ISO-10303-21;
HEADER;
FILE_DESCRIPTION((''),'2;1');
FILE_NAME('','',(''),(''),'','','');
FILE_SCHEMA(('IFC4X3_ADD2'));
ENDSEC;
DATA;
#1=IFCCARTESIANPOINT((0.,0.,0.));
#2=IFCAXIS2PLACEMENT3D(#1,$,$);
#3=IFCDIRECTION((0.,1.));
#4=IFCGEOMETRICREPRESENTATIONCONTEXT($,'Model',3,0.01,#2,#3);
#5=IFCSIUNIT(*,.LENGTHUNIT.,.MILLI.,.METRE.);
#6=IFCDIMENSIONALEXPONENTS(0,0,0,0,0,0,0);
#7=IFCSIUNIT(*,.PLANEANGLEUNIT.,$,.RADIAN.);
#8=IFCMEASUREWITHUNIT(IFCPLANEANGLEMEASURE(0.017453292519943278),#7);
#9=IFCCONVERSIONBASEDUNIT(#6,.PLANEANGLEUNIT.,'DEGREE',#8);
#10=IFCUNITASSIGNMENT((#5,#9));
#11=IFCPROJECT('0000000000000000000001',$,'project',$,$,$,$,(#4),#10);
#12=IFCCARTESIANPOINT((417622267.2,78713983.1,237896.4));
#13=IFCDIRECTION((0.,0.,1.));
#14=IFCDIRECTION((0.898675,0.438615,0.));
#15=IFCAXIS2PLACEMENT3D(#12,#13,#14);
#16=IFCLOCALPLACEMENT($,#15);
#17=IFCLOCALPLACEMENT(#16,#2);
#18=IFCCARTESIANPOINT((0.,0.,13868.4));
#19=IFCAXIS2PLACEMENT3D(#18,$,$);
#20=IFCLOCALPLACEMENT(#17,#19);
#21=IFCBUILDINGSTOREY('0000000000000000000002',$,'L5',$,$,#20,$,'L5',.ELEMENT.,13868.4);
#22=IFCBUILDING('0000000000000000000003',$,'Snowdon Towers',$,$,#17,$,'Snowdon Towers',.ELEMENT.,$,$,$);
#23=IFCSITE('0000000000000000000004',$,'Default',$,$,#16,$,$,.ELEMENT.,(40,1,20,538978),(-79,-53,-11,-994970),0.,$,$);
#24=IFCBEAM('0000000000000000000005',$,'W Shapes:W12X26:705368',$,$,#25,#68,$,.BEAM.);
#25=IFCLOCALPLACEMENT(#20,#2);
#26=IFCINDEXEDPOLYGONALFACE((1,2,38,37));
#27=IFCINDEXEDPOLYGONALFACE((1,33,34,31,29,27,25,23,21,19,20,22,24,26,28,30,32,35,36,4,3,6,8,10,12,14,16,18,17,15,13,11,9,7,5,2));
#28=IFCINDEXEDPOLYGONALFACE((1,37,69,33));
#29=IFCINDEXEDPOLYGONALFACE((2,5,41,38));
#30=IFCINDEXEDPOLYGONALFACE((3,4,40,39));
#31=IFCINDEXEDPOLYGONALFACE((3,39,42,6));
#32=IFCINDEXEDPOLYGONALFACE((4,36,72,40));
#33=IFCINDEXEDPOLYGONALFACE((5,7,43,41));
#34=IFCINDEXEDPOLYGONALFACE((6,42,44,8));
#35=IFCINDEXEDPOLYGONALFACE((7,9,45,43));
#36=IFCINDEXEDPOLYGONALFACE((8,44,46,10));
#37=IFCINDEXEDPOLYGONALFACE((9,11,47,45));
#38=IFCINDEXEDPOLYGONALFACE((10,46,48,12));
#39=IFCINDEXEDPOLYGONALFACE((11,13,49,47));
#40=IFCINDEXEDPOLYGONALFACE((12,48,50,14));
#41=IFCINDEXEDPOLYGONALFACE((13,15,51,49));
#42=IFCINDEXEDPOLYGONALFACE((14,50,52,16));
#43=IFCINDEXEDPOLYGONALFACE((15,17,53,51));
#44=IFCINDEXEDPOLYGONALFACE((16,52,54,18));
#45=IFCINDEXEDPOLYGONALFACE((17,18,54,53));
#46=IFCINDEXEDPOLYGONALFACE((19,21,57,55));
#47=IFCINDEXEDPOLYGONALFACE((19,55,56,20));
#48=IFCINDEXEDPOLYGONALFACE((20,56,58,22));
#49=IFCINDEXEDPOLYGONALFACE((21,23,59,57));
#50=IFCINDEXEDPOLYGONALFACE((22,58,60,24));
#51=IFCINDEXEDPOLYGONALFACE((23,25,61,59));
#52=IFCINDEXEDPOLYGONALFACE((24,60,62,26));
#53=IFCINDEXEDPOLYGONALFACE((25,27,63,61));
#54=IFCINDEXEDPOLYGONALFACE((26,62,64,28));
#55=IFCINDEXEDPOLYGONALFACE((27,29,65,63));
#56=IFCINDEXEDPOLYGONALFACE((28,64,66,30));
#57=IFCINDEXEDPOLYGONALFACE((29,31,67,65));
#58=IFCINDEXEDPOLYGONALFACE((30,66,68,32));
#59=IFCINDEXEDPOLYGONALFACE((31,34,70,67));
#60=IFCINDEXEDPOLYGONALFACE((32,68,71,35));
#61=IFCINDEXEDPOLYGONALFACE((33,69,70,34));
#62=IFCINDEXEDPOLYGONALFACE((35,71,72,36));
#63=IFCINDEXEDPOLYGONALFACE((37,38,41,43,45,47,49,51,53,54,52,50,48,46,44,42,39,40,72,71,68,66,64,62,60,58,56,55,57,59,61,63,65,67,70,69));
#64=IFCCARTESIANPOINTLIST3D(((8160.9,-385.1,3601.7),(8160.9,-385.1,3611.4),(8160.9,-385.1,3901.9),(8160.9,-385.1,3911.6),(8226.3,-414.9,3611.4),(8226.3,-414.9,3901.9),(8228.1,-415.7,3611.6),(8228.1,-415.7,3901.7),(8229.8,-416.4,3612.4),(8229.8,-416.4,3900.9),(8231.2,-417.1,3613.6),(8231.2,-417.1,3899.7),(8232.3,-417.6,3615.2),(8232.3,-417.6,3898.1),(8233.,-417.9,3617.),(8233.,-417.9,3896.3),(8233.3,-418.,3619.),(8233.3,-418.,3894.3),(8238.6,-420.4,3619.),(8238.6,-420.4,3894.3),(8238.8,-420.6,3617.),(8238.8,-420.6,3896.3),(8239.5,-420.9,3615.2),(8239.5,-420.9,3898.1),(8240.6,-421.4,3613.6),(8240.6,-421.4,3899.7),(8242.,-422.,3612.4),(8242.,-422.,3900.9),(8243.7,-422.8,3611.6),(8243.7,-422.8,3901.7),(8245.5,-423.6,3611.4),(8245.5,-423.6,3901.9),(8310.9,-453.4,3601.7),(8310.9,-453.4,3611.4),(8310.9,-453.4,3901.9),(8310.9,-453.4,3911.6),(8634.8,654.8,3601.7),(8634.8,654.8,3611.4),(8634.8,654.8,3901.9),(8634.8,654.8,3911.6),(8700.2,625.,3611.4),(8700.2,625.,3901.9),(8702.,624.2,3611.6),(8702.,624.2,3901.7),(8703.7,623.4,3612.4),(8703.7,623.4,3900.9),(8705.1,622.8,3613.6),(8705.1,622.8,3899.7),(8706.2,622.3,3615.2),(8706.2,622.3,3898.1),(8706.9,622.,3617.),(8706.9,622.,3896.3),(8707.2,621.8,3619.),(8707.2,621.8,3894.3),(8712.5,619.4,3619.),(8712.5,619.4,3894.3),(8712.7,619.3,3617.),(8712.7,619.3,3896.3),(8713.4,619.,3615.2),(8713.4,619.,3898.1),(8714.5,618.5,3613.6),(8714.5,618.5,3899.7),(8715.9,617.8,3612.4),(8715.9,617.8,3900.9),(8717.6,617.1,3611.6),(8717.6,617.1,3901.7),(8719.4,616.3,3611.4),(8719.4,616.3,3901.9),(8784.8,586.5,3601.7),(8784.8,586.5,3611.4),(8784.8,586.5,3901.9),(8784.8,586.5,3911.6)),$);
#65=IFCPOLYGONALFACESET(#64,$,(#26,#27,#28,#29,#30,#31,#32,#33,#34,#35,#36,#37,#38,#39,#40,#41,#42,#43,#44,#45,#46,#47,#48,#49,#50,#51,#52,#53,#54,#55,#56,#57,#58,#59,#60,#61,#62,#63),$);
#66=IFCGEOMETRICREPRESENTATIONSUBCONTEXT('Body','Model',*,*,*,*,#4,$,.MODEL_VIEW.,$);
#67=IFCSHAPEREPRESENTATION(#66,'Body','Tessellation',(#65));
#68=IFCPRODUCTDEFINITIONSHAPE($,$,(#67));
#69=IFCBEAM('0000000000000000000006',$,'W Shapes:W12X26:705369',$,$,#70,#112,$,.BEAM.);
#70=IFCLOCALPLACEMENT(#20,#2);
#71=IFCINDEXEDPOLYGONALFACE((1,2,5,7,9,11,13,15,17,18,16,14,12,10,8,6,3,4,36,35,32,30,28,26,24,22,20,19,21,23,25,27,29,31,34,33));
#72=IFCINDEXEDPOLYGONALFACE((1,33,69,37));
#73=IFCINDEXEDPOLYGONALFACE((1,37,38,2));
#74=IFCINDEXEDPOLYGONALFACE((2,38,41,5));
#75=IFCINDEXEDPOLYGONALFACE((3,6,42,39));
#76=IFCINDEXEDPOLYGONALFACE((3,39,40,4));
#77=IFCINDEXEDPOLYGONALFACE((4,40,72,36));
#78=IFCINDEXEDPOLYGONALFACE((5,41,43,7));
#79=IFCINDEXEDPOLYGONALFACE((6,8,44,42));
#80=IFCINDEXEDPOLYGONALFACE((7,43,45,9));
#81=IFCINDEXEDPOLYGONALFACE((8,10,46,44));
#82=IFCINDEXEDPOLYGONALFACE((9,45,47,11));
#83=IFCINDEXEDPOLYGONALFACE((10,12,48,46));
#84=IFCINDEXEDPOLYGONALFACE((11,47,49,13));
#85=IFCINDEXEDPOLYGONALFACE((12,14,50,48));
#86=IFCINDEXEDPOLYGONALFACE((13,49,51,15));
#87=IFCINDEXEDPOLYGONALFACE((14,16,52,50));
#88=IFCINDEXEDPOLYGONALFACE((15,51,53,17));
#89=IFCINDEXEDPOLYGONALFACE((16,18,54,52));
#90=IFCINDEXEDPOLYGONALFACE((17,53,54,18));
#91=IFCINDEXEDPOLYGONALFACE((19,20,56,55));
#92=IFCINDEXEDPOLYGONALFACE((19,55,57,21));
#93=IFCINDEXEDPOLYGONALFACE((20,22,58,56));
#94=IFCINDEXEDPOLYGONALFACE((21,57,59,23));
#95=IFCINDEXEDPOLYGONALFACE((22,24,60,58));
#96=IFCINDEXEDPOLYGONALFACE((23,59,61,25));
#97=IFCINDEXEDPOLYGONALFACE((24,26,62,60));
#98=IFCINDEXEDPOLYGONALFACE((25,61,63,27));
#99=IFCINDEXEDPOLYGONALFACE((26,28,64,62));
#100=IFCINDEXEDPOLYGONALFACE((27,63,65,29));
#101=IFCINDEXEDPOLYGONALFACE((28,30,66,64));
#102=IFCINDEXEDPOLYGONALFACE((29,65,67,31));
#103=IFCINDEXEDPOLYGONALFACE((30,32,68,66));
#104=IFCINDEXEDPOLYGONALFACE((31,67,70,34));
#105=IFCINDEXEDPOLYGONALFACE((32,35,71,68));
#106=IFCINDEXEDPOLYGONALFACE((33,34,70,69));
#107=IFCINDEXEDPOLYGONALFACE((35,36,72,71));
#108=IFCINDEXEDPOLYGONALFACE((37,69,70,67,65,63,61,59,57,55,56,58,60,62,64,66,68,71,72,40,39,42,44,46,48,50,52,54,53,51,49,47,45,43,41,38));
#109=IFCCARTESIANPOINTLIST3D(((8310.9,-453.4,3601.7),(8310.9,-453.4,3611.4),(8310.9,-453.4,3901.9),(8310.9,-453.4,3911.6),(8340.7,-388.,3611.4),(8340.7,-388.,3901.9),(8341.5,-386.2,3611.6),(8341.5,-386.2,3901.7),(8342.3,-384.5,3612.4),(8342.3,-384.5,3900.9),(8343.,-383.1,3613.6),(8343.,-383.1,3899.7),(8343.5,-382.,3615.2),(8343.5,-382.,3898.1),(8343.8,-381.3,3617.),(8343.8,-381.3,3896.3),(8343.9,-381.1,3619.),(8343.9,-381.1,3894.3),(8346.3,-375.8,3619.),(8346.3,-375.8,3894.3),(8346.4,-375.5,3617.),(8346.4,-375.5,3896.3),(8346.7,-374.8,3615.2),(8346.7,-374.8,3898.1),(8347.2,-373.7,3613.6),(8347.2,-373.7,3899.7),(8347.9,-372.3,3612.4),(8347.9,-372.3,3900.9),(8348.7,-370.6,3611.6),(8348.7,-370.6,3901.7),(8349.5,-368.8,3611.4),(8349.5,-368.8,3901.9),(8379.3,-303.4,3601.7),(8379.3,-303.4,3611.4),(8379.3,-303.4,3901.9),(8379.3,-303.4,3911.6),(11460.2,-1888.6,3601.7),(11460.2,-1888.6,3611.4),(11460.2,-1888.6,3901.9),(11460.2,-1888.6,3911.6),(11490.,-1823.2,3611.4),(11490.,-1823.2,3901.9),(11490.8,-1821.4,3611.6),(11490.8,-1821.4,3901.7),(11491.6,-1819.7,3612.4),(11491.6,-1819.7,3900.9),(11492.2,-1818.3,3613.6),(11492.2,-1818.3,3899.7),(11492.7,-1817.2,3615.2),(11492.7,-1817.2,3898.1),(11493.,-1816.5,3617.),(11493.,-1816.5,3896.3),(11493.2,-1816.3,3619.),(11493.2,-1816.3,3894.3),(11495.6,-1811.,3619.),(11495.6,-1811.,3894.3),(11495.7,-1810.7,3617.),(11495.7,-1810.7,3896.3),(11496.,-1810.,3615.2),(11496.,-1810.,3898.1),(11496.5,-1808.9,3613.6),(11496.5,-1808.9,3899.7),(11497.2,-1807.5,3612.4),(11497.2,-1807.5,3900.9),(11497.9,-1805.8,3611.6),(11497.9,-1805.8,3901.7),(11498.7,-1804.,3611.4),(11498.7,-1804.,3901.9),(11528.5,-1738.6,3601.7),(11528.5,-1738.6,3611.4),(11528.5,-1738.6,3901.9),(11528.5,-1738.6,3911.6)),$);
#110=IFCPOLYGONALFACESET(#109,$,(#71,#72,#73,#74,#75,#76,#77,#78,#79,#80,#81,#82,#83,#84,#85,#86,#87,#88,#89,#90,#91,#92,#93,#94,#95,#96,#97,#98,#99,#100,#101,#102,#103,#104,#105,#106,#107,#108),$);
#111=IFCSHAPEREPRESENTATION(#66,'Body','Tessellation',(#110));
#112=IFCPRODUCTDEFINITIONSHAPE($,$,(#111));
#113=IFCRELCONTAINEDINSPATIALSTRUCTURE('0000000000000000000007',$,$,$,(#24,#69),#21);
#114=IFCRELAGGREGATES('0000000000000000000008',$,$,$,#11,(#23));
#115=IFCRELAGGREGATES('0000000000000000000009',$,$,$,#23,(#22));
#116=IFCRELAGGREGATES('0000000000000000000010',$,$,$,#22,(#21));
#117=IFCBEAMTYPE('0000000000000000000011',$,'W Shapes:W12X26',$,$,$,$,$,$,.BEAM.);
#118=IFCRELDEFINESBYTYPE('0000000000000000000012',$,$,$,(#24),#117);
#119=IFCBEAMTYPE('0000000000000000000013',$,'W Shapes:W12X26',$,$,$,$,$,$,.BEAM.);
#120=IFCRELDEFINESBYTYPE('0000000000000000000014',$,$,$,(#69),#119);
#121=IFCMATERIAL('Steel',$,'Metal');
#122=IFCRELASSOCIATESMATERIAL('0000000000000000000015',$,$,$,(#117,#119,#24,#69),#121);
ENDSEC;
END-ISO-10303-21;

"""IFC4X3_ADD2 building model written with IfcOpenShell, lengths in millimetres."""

from ifc_helpers import new_model, entity, si_unit, converted_unit, direction, frame, frame_2d, origin, place, context, subcontext, project, spatial, polyline, circle_curve, parameter, trimmed, segment, composite_curve, outline, extrude, source, transform, mapped, material, material_profile, profile_set, profile_usage, type_object, type_shapes, element, save


model = new_model("IFC4X3_ADD2")

# Units and contexts
model_context = context("Model", 3, precision=0.01, world=origin(), true_north=direction((0.0, 1.0)))
body_context = subcontext(model_context, "Body", "Model", "MODEL_VIEW")
ifc_project = project(units=[si_unit("LENGTHUNIT", "METRE", prefix="MILLI"), converted_unit("PLANEANGLEUNIT", "DEGREE", entity("IfcPlaneAngleMeasure", 0.017453292519943278), si_unit("PLANEANGLEUNIT", "RADIAN"), dimensions=[0, 0, 0, 0, 0, 0, 0])], contexts=[model_context])

# Site, building, storey
site_placement = place(None, frame((417622267.2, 78713983.1, 237896.4), z_axis=(0.0, 0.0, 1.0), x_axis=(0.898675, 0.438615, 0.0)))
site = spatial("IfcSite", under=ifc_project, at=site_placement, Name="Default", CompositionType="ELEMENT", RefLatitude=(40, 1, 20, 538978), RefLongitude=(-79, -53, -11, -994970), RefElevation=0.0)
building_placement = place(site_placement, origin())
building = spatial("IfcBuilding", under=site, at=building_placement, Name="Snowdon Towers", LongName="Snowdon Towers", CompositionType="ELEMENT")
storey_placement = place(building_placement, frame((0.0, 0.0, 13868.4)))
storey = spatial("IfcBuildingStorey", under=building, at=storey_placement, Name="L5", LongName="L5", CompositionType="ELEMENT", Elevation=13868.4)

# Shared definitions
ifc_material_1 = material(Name="Steel", Category="Metal")

# Beams
ifc_material_profile_1 = material_profile(ifc_material_1, outline(composite_curve([segment(polyline([(-82.4, -145.3), (-82.4, -154.9)]), True, "CONTINUOUS"), segment(polyline([(-82.4, -154.9), (82.4, -154.9)]), True, "CONTINUOUS"), segment(polyline([(82.4, -154.9), (82.4, -145.3)]), True, "CONTINUOUS"), segment(polyline([(82.4, -145.3), (10.5, -145.3)]), True, "CONTINUOUS"), segment(trimmed(circle_curve(frame_2d((10.5, -137.7), x_axis=(1.0, 0.0)), 7.6), [parameter(180.0)], [parameter(270.0)], True, "PARAMETER"), False, "CONTINUOUS"), segment(polyline([(2.9, -137.7), (2.9, 137.7)]), True, "CONTINUOUS"), segment(trimmed(circle_curve(frame_2d((10.5, 137.7), x_axis=(1.0, 0.0)), 7.6), [parameter(90.0)], [parameter(180.0)], True, "PARAMETER"), False, "CONTINUOUS"), segment(polyline([(10.5, 145.3), (82.4, 145.3)]), True, "CONTINUOUS"), segment(polyline([(82.4, 145.3), (82.4, 154.9)]), True, "CONTINUOUS"), segment(polyline([(82.4, 154.9), (-82.4, 154.9)]), True, "CONTINUOUS"), segment(polyline([(-82.4, 154.9), (-82.4, 145.3)]), True, "CONTINUOUS"), segment(polyline([(-82.4, 145.3), (-10.5, 145.3)]), True, "CONTINUOUS"), segment(trimmed(circle_curve(frame_2d((-10.5, 137.7), x_axis=(1.0, 0.0)), 7.6), [parameter(360.0)], [parameter(90.0)], True, "PARAMETER"), False, "CONTINUOUS"), segment(polyline([(-2.9, 137.7), (-2.9, -137.7)]), True, "CONTINUOUS"), segment(trimmed(circle_curve(frame_2d((-10.5, -137.7), x_axis=(1.0, 0.0)), 7.6), [parameter(270.0)], [parameter(360.0)], True, "PARAMETER"), False, "CONTINUOUS"), segment(polyline([(-10.5, -145.3), (-82.4, -145.3)]), True, "CONTINUOUS")], self_intersect=False)), Name="W12X26")
ifc_profile_set_1 = profile_set([ifc_material_profile_1], Name="W12X26")
ifc_profile_usage_1 = profile_usage(ifc_profile_set_1, cardinal=8)
beam_type_1 = type_object("IfcBeamType", Name="W Shapes:W12X26", PredefinedType="BEAM", material=ifc_profile_set_1)
shared_shape_1 = source(origin(), body_context, "Body", "SweptSolid", [
    extrude(outline(composite_curve([segment(polyline([(145.3, -82.4), (154.9, -82.4)]), True, "CONTINUOUS"), segment(polyline([(154.9, -82.4), (154.9, 82.4)]), True, "CONTINUOUS"), segment(polyline([(154.9, 82.4), (145.3, 82.4)]), True, "CONTINUOUS"), segment(polyline([(145.3, 82.4), (145.3, 10.5)]), True, "CONTINUOUS"), segment(trimmed(circle_curve(frame_2d((137.7, 10.5), x_axis=(1.0, 0.0)), 7.6), [parameter(270.0)], [parameter(0.0)], True, "PARAMETER"), False, "CONTINUOUS"), segment(polyline([(137.7, 2.9), (-137.7, 2.9)]), True, "CONTINUOUS"), segment(trimmed(circle_curve(frame_2d((-137.7, 10.5), x_axis=(0.0, -1.0)), 7.6), [parameter(270.0)], [parameter(0.0)], True, "PARAMETER"), False, "CONTINUOUS"), segment(polyline([(-145.3, 10.5), (-145.3, 82.4)]), True, "CONTINUOUS"), segment(polyline([(-145.3, 82.4), (-154.9, 82.4)]), True, "CONTINUOUS"), segment(polyline([(-154.9, 82.4), (-154.9, -82.4)]), True, "CONTINUOUS"), segment(polyline([(-154.9, -82.4), (-145.3, -82.4)]), True, "CONTINUOUS"), segment(polyline([(-145.3, -82.4), (-145.3, -10.5)]), True, "CONTINUOUS"), segment(trimmed(circle_curve(frame_2d((-137.7, -10.5), x_axis=(-1.0, 0.0)), 7.6), [parameter(270.0)], [parameter(0.0)], True, "PARAMETER"), False, "CONTINUOUS"), segment(polyline([(-137.7, -2.9), (137.7, -2.9)]), True, "CONTINUOUS"), segment(trimmed(circle_curve(frame_2d((137.7, -10.5), x_axis=(0.0, 1.0)), 7.6), [parameter(270.0)], [parameter(0.0)], True, "PARAMETER"), False, "CONTINUOUS"), segment(polyline([(145.3, -10.5), (145.3, -82.4)]), True, "CONTINUOUS")], self_intersect=False)), frame((8235.9, -419.2, 17625.1), z_axis=(0.414693, 0.909961, 0.0), x_axis=(0.0, 0.0, 1.0)), (0.0, 0.0, 1.0), 1142.8),
])
type_shapes(beam_type_1, [shared_shape_1])
beam_1_placement = place(storey_placement, frame((0.0, 0.0, -13868.4)))
element("IfcBeam", 1, at=beam_1_placement, inside=storey, type_object=beam_type_1, material=ifc_profile_usage_1, Name="W Shapes:W12X26:705368", PredefinedType="BEAM", context=body_context, shape_type="MappedRepresentation", body=[
    mapped(shared_shape_1, transform((0.0, 0.0, 0.0), scale=1.0)),
])
beam_type_2 = type_object("IfcBeamType", Name="W Shapes:W12X26", PredefinedType="BEAM", material=ifc_profile_set_1)
shared_shape_2 = source(origin(), body_context, "Body", "SweptSolid", [
    extrude(outline(composite_curve([segment(polyline([(-82.4, -145.3), (-82.4, -154.9)]), True, "CONTINUOUS"), segment(polyline([(-82.4, -154.9), (82.4, -154.9)]), True, "CONTINUOUS"), segment(polyline([(82.4, -154.9), (82.4, -145.3)]), True, "CONTINUOUS"), segment(polyline([(82.4, -145.3), (10.5, -145.3)]), True, "CONTINUOUS"), segment(trimmed(circle_curve(frame_2d((10.5, -137.7), x_axis=(0.0, -1.0)), 7.6), [parameter(270.0)], [parameter(360.0)], True, "PARAMETER"), False, "CONTINUOUS"), segment(polyline([(2.9, -137.7), (2.9, 137.7)]), True, "CONTINUOUS"), segment(trimmed(circle_curve(frame_2d((10.5, 137.7), x_axis=(-1.0, 0.0)), 7.6), [parameter(270.0)], [parameter(360.0)], True, "PARAMETER"), False, "CONTINUOUS"), segment(polyline([(10.5, 145.3), (82.4, 145.3)]), True, "CONTINUOUS"), segment(polyline([(82.4, 145.3), (82.4, 154.9)]), True, "CONTINUOUS"), segment(polyline([(82.4, 154.9), (-82.4, 154.9)]), True, "CONTINUOUS"), segment(polyline([(-82.4, 154.9), (-82.4, 145.3)]), True, "CONTINUOUS"), segment(polyline([(-82.4, 145.3), (-10.5, 145.3)]), True, "CONTINUOUS"), segment(trimmed(circle_curve(frame_2d((-10.5, 137.7), x_axis=(0.0, 1.0)), 7.6), [parameter(270.0)], [parameter(0.0)], True, "PARAMETER"), False, "CONTINUOUS"), segment(polyline([(-2.9, 137.7), (-2.9, -137.7)]), True, "CONTINUOUS"), segment(trimmed(circle_curve(frame_2d((-10.5, -137.7), x_axis=(1.0, 0.0)), 7.6), [parameter(270.0)], [parameter(0.0)], True, "PARAMETER"), False, "CONTINUOUS"), segment(polyline([(-10.5, -145.3), (-82.4, -145.3)]), True, "CONTINUOUS")], self_intersect=False)), frame((-1746.4, 0.0, 0.0), z_axis=(-1.0, 0.0, 0.0), x_axis=(0.0, -1.0, 0.0)), (0.0, 0.0, -1.0), 3460.9),
])
type_shapes(beam_type_2, [shared_shape_2])
beam_2_placement = place(storey_placement, frame((9934.2, -1102.6, 3756.7), z_axis=(0.0, 0.0, 1.0), x_axis=(0.909961, -0.414693, 0.0)))
element("IfcBeam", 2, at=beam_2_placement, inside=storey, type_object=beam_type_2, material=ifc_profile_usage_1, Name="W Shapes:W12X26:705369", PredefinedType="BEAM", context=body_context, shape_type="MappedRepresentation", body=[
    mapped(shared_shape_2, transform((0.0, 0.0, 0.0), scale=1.0)),
])

save(model, "model.ifc")
